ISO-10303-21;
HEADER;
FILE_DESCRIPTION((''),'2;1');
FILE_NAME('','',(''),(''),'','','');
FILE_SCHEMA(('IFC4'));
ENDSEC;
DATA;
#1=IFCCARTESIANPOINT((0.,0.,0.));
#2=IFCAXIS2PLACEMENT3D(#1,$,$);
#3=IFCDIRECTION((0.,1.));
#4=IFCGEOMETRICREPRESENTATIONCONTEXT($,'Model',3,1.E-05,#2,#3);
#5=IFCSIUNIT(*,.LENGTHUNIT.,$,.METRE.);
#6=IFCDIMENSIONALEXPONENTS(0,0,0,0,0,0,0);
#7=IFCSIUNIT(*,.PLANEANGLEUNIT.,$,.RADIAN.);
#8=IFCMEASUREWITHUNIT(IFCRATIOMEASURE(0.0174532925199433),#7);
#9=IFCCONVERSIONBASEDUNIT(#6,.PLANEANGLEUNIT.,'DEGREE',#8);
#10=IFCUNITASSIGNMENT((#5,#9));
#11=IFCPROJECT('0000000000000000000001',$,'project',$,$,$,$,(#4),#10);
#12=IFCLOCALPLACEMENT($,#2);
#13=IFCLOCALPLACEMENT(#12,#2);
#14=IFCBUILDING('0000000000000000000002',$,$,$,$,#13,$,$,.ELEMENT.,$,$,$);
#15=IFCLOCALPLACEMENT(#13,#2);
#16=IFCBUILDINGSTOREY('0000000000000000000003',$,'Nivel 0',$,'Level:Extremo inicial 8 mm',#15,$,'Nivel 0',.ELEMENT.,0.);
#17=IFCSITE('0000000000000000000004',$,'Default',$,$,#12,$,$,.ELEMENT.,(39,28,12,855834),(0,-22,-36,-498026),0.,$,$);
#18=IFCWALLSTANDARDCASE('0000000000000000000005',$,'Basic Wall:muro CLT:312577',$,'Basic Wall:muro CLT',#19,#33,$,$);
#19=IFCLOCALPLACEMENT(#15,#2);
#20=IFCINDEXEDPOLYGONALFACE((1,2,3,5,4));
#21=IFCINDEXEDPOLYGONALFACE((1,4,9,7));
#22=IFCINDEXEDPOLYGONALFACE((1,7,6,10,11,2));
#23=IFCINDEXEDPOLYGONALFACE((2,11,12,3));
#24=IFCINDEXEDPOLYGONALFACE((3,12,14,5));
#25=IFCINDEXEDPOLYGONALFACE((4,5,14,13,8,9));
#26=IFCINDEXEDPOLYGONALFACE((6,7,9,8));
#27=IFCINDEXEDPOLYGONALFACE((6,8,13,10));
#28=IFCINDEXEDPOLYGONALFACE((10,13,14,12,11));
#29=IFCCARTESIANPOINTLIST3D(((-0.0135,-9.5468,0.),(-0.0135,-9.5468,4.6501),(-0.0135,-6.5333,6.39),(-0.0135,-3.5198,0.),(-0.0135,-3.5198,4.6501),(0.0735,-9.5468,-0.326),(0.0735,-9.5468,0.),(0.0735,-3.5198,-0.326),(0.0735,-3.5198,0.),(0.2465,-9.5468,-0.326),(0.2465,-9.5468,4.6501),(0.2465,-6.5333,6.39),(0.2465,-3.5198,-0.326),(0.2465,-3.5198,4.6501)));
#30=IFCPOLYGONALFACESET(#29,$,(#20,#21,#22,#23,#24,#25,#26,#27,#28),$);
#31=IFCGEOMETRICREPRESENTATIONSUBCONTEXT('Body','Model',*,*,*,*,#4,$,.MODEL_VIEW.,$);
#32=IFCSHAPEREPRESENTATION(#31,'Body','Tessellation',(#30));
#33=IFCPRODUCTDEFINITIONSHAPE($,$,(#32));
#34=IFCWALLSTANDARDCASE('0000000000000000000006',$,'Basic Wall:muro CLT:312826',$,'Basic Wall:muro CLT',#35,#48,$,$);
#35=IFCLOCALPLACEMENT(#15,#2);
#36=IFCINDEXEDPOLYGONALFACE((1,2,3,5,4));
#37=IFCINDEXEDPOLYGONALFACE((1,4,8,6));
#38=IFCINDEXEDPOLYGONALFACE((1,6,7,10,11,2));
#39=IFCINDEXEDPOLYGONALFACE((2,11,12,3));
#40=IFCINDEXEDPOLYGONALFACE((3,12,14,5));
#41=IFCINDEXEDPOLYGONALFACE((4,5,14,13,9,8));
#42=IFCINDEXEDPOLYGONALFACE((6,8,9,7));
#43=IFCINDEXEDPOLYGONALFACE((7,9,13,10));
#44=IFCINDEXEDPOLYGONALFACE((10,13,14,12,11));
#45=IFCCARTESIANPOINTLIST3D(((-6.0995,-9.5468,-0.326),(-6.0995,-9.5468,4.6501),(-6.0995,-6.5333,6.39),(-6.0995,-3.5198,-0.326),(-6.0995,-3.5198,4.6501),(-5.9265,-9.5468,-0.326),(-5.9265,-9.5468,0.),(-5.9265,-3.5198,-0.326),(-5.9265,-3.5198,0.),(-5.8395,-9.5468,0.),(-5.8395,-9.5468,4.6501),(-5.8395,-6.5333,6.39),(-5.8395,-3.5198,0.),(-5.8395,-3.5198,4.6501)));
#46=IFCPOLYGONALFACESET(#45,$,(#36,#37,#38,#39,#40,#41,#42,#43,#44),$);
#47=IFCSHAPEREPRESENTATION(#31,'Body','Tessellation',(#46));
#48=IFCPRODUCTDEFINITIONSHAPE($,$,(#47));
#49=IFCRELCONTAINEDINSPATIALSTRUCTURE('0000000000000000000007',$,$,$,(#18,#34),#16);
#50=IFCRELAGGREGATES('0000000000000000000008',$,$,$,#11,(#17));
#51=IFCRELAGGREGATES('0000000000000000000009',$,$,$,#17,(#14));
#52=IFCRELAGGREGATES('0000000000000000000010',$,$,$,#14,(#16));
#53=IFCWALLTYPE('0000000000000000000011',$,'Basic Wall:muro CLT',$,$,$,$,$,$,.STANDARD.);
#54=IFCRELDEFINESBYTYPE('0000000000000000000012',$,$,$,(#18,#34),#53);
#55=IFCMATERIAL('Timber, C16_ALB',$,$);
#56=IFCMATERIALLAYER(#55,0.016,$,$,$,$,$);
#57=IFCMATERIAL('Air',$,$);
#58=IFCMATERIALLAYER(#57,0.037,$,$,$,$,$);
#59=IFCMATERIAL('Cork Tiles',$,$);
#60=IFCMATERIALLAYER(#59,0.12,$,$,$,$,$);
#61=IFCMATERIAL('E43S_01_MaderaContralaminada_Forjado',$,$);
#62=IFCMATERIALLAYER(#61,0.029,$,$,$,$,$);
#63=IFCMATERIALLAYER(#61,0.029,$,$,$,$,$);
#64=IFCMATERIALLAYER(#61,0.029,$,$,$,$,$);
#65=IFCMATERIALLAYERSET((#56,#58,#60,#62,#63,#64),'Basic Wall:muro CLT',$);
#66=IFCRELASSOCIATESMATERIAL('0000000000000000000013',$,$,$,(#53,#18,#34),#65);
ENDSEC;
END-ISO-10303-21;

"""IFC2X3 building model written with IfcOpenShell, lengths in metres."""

from ifc_helpers import new_model, entity, si_unit, converted_unit, direction, frame, frame_2d, origin, place, context, subcontext, project, spatial, polyline, rectangle, extrude, clip, bounded_halfspace, material, layer, layer_set, layer_usage, type_object, element, save


model = new_model("IFC2X3")

# Units and contexts
model_context = context("Model", 3, precision=1e-05, world=origin(), true_north=direction((0.0, 1.0)))
body_context = subcontext(model_context, "Body", "Model", "MODEL_VIEW")
ifc_project = project(units=[si_unit("LENGTHUNIT", "METRE"), converted_unit("PLANEANGLEUNIT", "DEGREE", entity("IfcRatioMeasure", 0.0174532925199433), si_unit("PLANEANGLEUNIT", "RADIAN"), dimensions=[0, 0, 0, 0, 0, 0, 0])], contexts=[model_context])

# Site, building, storey
site_placement = place(None, origin())
site = spatial("IfcSite", under=ifc_project, at=site_placement, Name="Default", CompositionType="ELEMENT", RefLatitude=(39, 28, 12, 855834), RefLongitude=(0, -22, -36, -498026), RefElevation=0.0)
building_placement = place(site_placement, origin())
building = spatial("IfcBuilding", under=site, at=building_placement, CompositionType="ELEMENT")
storey_placement = place(building_placement, origin())
storey = spatial("IfcBuildingStorey", under=building, at=storey_placement, Name="Nivel 0", ObjectType="Level:Extremo inicial 8 mm", LongName="Nivel 0", CompositionType="ELEMENT", Elevation=0.0)

# Shared definitions
ifc_material_1 = material(Name="E43S_01_MaderaContralaminada_Forjado")
ifc_material_2 = material(Name="Cork Tiles")

# Shared definitions
ifc_material_3 = material(Name="Timber, C16_ALB")
ifc_layer_1 = layer(ifc_material_3, 0.016)
ifc_material_4 = material(Name="Air")
ifc_layer_2 = layer(ifc_material_4, 0.037)
ifc_layer_3 = layer(ifc_material_2, 0.12)
ifc_layer_4 = layer(ifc_material_1, 0.029)
ifc_layer_5 = layer(ifc_material_1, 0.029)
ifc_layer_6 = layer(ifc_material_1, 0.029)
ifc_layer_set_1 = layer_set([ifc_layer_1, ifc_layer_2, ifc_layer_3, ifc_layer_4, ifc_layer_5, ifc_layer_6], Name="Basic Wall:muro CLT")
wall_type = type_object("IfcWallType", Name="Basic Wall:muro CLT", PredefinedType="STANDARD", material=ifc_layer_set_1)

# Walls
ifc_layer_usage_1 = layer_usage(ifc_layer_set_1, "AXIS2", "NEGATIVE", 0.13)
wall_1_placement = place(storey_placement, frame((0.1165, -3.5198, -0.326), z_axis=(0.0, 0.0, 1.0), x_axis=(0.0, -1.0, 0.0)))
element("IfcWallStandardCase", 1, at=wall_1_placement, inside=storey, type_object=wall_type, material=ifc_layer_usage_1, Name="Basic Wall:muro CLT:312577", ObjectType="Basic Wall:muro CLT", context=body_context, shape_type="Clipping", body=[
    clip(clip(clip(clip(extrude(rectangle(XDim=6.027, YDim=0.26, at=frame_2d((3.0135, 0.0), x_axis=(-1.0, 0.0))), origin(), (0.0, 0.0, 1.0), 6.716), bounded_halfspace(frame((0.0, 0.13, 4.9761), z_axis=(-0.5, 0.0, 0.866025), x_axis=(0.0, -1.0, 0.0)), False, frame((0.0, 0.13, 4.9761)), polyline([(0.0, 0.0), (0.0, -0.26), (3.0135, -0.26), (3.0135, 0.0), (0.0, 0.0)]))), bounded_halfspace(frame((3.0135, -0.13, 6.716), z_axis=(0.5, 0.0, 0.866025), x_axis=(0.0, 1.0, 0.0)), False, frame((3.0135, -0.13, 6.716)), polyline([(0.0, 0.0), (3.0135, 0.0), (3.0135, 0.26), (0.0, 0.26), (0.0, 0.0)]))), bounded_halfspace(frame((0.0, -0.043, 0.326), z_axis=(0.0, 0.0, 1.0), x_axis=(-1.0, 0.0, 0.0)), True, frame((0.0, -0.043, 0.326), z_axis=(0.0, 0.0, 1.0), x_axis=(-1.0, 0.0, 0.0)), polyline([(0.0, 0.0), (0.0, 0.087), (-6.027, 0.087), (-6.027, 0.0), (0.0, 0.0)]))), bounded_halfspace(frame((6.027, -0.043, 0.326), z_axis=(0.0, 1.0, 0.0), x_axis=(0.0, 0.0, 1.0)), True, frame((6.027, -0.043, 0.326), z_axis=(0.0, 1.0, 0.0), x_axis=(0.0, 0.0, 1.0)), polyline([(0.0, 0.0), (-0.326, 0.0), (-0.326, -6.027), (0.0, -6.027), (0.0, 0.0)]))),
])
ifc_layer_usage_2 = layer_usage(ifc_layer_set_1, "AXIS2", "NEGATIVE", 0.13)
wall_2_placement = place(storey_placement, frame((-5.9695, -9.5468, -0.326), z_axis=(0.0, 0.0, 1.0), x_axis=(0.0, 1.0, 0.0)))
element("IfcWallStandardCase", 2, at=wall_2_placement, inside=storey, type_object=wall_type, material=ifc_layer_usage_2, Name="Basic Wall:muro CLT:312826", ObjectType="Basic Wall:muro CLT", context=body_context, shape_type="Clipping", body=[
    clip(clip(clip(clip(extrude(rectangle(XDim=6.027, YDim=0.26, at=frame_2d((3.0135, 0.0), x_axis=(-1.0, 0.0))), origin(), (0.0, 0.0, 1.0), 6.716), bounded_halfspace(frame((6.027, -0.13, 4.9761), z_axis=(0.5, 0.0, 0.866025), x_axis=(0.0, 1.0, 0.0)), False, frame((6.027, -0.13, 4.9761)), polyline([(0.0, 0.0), (0.0, 0.26), (-3.0135, 0.26), (-3.0135, 0.0), (0.0, 0.0)]))), bounded_halfspace(frame((0.0, 0.13, 4.9761), z_axis=(-0.5, 0.0, 0.866025), x_axis=(0.0, -1.0, 0.0)), False, frame((0.0, 0.13, 4.9761)), polyline([(0.0, 0.0), (0.0, -0.26), (3.0135, -0.26), (3.0135, 0.0), (0.0, 0.0)]))), bounded_halfspace(frame((0.0, -0.043, 0.326)), True, frame((0.0, -0.043, 0.326)), polyline([(0.0, 0.0), (0.0, -0.087), (6.027, -0.087), (6.027, 0.0), (0.0, 0.0)]))), bounded_halfspace(frame((6.027, -0.043, 0.326), z_axis=(0.0, 1.0, 0.0), x_axis=(0.0, 0.0, 1.0)), True, frame((6.027, -0.043, 0.326), z_axis=(0.0, 1.0, 0.0), x_axis=(0.0, 0.0, 1.0)), polyline([(0.0, 0.0), (-0.326, 0.0), (-0.326, -6.027), (0.0, -6.027), (0.0, 0.0)]))),
])

save(model, "model.ifc")
